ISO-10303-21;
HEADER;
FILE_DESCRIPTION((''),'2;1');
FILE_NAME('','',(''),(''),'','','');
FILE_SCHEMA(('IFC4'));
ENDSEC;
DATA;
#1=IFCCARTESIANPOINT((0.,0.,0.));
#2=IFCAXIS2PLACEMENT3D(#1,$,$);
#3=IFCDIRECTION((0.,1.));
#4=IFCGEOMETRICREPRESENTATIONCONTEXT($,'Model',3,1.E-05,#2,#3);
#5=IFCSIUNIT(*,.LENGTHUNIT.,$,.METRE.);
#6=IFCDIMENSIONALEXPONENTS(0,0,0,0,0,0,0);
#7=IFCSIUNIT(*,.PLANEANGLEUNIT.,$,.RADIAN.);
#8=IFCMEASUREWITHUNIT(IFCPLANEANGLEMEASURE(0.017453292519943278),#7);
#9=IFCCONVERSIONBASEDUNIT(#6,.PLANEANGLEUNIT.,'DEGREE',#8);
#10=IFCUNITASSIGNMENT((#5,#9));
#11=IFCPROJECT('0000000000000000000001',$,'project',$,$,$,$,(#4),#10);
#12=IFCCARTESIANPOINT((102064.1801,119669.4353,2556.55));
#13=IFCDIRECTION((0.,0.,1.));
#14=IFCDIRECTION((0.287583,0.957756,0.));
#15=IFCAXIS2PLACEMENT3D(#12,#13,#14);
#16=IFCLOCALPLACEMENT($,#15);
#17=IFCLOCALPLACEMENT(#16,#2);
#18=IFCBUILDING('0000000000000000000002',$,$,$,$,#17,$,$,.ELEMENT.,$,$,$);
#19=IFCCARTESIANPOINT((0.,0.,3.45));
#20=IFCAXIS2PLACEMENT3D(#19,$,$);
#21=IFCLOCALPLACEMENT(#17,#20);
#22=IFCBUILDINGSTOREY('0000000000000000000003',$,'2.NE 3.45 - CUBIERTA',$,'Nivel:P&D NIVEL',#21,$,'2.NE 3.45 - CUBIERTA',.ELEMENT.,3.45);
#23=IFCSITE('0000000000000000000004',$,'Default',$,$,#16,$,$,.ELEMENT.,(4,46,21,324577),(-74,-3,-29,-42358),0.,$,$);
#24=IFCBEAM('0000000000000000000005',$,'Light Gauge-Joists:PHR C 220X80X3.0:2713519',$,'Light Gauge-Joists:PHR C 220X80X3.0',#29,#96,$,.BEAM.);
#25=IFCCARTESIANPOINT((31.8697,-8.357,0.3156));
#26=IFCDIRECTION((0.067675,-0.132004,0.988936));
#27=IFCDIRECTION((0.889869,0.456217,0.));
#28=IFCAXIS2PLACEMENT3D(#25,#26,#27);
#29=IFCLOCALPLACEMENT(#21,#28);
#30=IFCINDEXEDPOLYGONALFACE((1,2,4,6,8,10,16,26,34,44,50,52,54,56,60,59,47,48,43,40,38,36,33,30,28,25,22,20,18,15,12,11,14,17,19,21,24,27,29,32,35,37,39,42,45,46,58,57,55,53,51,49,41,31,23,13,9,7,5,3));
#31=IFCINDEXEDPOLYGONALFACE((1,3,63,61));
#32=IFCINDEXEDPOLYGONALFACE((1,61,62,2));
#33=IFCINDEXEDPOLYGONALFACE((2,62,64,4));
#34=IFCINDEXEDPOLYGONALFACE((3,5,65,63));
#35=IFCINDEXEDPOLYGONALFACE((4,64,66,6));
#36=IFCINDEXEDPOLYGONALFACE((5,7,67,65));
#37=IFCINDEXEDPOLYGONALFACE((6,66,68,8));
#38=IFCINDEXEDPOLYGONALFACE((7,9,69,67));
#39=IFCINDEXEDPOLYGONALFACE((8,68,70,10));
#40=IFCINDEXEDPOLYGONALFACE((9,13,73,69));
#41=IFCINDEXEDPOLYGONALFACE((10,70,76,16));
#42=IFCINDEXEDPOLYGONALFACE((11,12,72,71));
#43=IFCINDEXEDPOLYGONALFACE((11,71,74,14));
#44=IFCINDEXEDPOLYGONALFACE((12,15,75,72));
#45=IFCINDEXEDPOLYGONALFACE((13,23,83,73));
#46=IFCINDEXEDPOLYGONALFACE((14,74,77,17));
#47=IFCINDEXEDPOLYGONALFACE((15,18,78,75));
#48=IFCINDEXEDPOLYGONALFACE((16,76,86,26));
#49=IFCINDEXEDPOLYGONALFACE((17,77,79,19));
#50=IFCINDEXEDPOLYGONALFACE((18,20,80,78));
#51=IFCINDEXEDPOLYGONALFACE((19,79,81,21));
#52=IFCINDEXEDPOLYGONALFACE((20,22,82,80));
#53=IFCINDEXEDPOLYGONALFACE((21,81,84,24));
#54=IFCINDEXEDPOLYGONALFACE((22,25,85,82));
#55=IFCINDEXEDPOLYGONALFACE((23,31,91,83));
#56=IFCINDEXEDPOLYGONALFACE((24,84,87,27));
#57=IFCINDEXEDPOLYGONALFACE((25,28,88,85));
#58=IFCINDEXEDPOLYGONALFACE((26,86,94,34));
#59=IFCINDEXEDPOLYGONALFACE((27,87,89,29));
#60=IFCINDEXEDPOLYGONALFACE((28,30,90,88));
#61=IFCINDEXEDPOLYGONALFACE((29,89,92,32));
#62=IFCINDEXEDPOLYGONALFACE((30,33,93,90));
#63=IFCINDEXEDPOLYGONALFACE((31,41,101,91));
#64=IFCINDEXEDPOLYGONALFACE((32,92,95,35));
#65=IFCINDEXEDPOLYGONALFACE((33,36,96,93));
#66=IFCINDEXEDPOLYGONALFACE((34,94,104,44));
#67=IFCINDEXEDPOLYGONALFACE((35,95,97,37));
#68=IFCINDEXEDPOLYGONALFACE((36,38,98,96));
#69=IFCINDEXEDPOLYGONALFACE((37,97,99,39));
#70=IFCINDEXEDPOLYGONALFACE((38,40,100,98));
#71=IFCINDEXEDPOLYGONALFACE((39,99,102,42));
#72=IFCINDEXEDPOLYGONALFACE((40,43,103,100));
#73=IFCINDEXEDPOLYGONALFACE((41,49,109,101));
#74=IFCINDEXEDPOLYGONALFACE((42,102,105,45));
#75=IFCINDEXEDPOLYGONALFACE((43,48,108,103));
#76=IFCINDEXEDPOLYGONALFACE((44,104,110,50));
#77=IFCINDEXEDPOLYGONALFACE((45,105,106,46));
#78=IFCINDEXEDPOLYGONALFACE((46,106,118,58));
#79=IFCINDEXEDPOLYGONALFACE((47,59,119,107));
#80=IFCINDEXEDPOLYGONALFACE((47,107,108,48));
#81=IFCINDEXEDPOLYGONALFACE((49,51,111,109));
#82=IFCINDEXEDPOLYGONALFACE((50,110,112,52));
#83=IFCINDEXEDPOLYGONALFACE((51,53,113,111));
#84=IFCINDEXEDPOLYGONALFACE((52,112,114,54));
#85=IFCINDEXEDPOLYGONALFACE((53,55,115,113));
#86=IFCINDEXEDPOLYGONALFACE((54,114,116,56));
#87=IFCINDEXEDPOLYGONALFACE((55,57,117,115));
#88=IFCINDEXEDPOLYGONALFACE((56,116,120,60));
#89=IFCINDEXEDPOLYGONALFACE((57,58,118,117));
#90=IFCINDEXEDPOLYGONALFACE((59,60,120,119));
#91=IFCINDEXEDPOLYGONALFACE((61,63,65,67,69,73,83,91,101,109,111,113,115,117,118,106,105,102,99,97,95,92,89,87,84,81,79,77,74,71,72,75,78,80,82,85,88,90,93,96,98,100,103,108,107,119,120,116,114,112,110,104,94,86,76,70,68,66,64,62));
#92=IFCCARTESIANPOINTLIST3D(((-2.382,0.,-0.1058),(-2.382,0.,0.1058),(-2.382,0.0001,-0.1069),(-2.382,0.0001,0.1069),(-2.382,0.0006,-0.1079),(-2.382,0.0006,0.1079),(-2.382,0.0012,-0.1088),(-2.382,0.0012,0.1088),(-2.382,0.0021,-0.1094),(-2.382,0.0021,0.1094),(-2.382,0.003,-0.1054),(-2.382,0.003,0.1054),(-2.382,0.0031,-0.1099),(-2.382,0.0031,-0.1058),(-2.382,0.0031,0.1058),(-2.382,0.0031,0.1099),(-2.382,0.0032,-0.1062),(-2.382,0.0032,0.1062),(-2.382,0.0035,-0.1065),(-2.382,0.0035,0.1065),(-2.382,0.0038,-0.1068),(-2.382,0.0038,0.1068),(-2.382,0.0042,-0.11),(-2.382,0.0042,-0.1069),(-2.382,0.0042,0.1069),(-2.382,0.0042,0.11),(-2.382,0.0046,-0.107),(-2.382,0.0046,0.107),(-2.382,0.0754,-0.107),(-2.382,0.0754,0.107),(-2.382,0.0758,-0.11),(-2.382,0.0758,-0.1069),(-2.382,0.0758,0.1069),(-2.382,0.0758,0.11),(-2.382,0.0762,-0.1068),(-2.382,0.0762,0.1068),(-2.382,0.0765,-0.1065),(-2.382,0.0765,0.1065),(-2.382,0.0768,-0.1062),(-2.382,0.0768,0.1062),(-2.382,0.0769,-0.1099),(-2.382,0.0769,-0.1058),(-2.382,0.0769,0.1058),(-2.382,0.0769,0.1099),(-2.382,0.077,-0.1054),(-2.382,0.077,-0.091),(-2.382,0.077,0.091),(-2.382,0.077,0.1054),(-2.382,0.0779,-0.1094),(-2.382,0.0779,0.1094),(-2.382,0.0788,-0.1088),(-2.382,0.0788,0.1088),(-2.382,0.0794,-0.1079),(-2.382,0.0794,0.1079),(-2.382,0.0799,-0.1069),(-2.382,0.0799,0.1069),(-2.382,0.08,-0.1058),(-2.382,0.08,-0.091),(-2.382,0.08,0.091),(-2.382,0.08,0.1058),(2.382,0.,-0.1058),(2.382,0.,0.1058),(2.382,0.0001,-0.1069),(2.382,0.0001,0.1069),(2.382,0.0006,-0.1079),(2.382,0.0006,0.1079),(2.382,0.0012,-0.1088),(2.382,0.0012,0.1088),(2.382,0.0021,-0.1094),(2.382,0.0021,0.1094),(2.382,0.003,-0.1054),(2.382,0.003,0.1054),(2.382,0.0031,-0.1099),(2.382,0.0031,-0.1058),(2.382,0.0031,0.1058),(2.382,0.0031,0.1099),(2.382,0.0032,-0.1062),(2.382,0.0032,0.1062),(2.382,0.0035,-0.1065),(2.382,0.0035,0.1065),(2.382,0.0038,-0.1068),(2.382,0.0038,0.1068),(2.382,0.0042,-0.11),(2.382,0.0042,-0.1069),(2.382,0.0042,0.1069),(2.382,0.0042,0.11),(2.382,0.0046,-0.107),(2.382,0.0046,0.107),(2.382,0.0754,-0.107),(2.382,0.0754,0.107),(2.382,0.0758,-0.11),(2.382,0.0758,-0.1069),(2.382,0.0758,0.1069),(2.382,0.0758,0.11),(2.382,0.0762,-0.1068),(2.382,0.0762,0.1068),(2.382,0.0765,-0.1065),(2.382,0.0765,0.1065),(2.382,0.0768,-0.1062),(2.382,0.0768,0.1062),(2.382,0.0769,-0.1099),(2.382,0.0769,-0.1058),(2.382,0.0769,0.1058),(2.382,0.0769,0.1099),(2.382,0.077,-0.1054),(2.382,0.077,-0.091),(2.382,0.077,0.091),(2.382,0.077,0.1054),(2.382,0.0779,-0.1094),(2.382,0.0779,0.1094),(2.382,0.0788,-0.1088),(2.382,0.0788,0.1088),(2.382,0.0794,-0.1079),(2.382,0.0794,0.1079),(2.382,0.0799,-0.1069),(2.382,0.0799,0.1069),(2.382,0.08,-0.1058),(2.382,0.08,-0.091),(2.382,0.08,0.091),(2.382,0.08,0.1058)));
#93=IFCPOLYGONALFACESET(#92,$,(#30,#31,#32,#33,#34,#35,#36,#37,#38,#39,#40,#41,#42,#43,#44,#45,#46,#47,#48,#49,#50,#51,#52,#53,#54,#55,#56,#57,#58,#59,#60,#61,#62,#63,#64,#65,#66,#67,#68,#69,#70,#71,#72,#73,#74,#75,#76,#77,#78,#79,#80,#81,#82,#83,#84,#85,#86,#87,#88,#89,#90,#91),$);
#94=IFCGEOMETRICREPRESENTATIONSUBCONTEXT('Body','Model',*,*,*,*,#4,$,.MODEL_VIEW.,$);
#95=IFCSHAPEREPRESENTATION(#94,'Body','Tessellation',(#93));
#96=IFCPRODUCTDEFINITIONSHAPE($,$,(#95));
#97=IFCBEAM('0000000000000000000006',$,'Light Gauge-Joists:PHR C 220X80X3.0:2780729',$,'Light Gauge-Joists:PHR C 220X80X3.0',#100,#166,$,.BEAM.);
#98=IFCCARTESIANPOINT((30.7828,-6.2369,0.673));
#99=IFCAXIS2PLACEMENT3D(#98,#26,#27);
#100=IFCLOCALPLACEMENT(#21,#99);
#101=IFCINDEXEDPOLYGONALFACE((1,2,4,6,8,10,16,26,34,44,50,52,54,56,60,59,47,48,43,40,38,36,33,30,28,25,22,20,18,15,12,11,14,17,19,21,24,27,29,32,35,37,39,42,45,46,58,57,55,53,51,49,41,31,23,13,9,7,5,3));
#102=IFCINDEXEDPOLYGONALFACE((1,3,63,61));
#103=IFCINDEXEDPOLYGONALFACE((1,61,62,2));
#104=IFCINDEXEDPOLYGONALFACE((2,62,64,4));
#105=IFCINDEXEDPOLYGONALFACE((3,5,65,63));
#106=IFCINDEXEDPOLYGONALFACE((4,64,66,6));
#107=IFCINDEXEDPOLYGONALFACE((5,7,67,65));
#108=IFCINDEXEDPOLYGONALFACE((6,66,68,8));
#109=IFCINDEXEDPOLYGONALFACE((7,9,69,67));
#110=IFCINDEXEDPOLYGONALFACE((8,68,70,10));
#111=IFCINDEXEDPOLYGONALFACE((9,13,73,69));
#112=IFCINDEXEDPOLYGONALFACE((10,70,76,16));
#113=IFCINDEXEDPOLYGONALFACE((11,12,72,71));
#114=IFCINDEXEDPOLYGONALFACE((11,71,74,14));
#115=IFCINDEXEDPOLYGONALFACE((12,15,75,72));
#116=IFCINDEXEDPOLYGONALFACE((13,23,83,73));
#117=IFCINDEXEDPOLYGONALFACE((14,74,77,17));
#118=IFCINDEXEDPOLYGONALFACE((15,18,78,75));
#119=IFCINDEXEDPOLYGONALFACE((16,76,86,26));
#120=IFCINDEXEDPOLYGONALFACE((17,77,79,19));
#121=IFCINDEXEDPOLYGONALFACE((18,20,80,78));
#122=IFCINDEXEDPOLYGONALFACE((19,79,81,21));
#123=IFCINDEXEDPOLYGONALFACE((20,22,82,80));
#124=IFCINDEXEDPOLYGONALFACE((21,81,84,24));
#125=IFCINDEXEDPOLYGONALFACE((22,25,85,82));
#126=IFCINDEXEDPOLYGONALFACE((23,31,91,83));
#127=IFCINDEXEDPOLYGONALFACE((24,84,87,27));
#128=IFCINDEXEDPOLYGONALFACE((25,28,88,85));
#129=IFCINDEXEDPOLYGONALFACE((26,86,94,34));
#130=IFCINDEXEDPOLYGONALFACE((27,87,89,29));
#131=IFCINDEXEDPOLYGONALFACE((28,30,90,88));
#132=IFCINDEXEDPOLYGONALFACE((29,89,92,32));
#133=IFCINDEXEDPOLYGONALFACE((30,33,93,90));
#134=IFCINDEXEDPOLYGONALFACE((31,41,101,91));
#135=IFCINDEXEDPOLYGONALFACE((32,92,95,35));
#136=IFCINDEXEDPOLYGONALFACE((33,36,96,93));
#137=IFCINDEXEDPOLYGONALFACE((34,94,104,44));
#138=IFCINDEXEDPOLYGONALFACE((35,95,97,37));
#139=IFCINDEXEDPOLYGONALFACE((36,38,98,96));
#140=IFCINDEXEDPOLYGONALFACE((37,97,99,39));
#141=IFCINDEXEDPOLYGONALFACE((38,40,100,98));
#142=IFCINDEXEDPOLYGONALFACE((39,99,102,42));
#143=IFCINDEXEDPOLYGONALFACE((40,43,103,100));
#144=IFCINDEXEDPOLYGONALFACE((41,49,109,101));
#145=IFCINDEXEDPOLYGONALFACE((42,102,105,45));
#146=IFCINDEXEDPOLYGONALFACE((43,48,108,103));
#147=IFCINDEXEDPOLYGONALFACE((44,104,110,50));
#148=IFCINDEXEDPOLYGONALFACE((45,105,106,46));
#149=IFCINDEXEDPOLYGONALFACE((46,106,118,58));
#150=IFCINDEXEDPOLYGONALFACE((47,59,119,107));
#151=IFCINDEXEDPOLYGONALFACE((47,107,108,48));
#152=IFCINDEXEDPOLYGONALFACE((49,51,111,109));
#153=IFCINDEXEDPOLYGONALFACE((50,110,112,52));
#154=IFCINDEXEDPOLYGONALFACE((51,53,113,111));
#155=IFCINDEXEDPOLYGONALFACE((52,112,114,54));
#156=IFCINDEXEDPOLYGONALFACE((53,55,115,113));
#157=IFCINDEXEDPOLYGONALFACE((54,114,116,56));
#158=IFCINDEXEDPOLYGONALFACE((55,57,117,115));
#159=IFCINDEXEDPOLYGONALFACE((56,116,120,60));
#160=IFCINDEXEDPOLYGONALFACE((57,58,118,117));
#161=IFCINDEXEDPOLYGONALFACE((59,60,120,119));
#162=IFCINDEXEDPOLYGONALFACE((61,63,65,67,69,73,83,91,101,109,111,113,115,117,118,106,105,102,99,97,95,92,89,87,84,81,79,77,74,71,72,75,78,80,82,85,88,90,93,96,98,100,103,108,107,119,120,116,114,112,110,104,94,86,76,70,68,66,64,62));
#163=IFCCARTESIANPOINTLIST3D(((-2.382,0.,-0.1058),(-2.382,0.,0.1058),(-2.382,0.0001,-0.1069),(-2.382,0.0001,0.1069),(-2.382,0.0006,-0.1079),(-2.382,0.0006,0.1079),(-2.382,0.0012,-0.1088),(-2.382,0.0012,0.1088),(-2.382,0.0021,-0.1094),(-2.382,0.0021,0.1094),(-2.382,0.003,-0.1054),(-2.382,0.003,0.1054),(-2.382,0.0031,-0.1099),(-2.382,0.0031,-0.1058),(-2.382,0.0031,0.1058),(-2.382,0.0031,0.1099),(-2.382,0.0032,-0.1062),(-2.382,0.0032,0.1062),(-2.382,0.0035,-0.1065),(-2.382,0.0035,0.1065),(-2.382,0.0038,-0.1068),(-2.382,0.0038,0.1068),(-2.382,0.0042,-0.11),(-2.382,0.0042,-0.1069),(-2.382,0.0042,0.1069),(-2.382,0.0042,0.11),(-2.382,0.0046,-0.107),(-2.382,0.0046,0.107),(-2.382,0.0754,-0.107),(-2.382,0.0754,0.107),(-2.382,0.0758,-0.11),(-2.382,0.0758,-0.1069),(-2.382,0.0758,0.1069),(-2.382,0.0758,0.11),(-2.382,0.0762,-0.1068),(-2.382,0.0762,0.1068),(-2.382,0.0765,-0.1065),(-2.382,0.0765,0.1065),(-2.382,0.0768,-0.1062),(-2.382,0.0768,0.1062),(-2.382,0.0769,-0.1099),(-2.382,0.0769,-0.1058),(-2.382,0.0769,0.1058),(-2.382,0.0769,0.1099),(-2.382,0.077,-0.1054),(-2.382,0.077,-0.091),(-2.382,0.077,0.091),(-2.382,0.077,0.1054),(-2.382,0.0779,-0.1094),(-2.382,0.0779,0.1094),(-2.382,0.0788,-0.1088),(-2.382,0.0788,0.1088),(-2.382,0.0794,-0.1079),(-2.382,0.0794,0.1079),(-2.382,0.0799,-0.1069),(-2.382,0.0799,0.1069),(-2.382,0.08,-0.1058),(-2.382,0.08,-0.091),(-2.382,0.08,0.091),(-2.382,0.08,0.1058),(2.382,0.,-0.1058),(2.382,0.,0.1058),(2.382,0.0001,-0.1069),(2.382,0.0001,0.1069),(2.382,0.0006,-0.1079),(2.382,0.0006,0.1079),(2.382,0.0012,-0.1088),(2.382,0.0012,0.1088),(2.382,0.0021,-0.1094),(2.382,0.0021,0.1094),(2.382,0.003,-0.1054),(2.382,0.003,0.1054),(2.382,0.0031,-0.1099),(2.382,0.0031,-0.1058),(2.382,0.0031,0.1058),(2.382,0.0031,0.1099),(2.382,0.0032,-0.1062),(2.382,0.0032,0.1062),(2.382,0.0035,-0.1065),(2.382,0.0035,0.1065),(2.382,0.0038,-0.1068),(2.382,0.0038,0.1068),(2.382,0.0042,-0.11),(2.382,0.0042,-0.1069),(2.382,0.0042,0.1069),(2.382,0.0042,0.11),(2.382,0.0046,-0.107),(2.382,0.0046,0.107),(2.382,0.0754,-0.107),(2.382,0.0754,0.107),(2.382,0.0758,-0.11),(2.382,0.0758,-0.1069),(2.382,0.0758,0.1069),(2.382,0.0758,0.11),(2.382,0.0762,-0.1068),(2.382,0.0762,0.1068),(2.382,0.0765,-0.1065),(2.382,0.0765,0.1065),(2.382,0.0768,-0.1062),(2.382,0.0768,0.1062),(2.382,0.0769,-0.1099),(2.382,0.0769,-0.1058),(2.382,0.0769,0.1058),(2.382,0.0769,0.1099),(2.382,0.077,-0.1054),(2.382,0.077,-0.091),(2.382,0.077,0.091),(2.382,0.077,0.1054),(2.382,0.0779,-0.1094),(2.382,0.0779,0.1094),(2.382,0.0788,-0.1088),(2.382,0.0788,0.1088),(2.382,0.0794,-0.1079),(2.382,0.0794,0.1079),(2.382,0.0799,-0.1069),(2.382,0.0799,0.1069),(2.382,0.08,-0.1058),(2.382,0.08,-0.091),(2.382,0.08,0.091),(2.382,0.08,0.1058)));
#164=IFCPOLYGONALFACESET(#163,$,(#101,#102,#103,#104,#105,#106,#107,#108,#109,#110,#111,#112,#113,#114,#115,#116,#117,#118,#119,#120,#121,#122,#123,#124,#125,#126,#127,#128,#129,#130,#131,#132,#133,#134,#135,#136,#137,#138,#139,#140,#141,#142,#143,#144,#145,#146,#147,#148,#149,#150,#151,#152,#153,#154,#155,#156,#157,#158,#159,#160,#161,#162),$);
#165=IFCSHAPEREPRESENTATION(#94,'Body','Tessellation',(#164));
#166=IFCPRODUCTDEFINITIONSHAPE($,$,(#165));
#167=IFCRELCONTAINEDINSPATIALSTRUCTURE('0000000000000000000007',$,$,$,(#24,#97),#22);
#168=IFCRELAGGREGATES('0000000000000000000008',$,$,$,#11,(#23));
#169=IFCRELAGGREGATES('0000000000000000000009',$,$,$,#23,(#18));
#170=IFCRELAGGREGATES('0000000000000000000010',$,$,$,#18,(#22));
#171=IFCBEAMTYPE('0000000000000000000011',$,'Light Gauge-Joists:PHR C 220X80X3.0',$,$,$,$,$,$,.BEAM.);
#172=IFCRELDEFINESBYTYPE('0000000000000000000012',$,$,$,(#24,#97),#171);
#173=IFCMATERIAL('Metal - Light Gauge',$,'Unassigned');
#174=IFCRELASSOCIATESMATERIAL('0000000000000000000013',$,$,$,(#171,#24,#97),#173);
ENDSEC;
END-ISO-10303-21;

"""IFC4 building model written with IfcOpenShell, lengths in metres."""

from ifc_helpers import new_model, entity, si_unit, converted_unit, direction, frame, origin, place, context, subcontext, project, spatial, line, arc, indexed_curve, outline, extrude, source, transform, mapped, material, type_object, type_shapes, element, save


model = new_model("IFC4")

# Units and contexts
model_context = context("Model", 3, precision=1e-05, world=origin(), true_north=direction((0.0, 1.0)))
body_context = subcontext(model_context, "Body", "Model", "MODEL_VIEW")
ifc_project = project(units=[si_unit("LENGTHUNIT", "METRE"), converted_unit("PLANEANGLEUNIT", "DEGREE", entity("IfcPlaneAngleMeasure", 0.017453292519943278), si_unit("PLANEANGLEUNIT", "RADIAN"), dimensions=[0, 0, 0, 0, 0, 0, 0])], contexts=[model_context])

# Site, building, storey
site_placement = place(None, frame((102064.1801, 119669.4353, 2556.55), z_axis=(0.0, 0.0, 1.0), x_axis=(0.287583, 0.957756, 0.0)))
site = spatial("IfcSite", under=ifc_project, at=site_placement, Name="Default", CompositionType="ELEMENT", RefLatitude=(4, 46, 21, 324577), RefLongitude=(-74, -3, -29, -42358), RefElevation=0.0)
building_placement = place(site_placement, origin())
building = spatial("IfcBuilding", under=site, at=building_placement, CompositionType="ELEMENT")
storey_placement = place(building_placement, frame((0.0, 0.0, 3.45)))
storey = spatial("IfcBuildingStorey", under=building, at=storey_placement, Name="2.NE 3.45 - CUBIERTA", ObjectType="Nivel:P&D NIVEL", LongName="2.NE 3.45 - CUBIERTA", CompositionType="ELEMENT", Elevation=3.45)

# Beams
ifc_material_1 = material(Name="Metal - Light Gauge", Category="Unassigned")
beam_type_1 = type_object("IfcBeamType", Name="Light Gauge-Joists:PHR C 220X80X3.0", PredefinedType="BEAM", material=ifc_material_1)
shared_shape_1 = source(origin(), body_context, "Body", "SweptSolid", [
    extrude(outline(indexed_curve([(-0.0477, -0.1058), (-0.0465, -0.1088), (-0.0435, -0.11), (0.0281, -0.11), (0.0311, -0.1088), (0.0323, -0.1058), (0.0323, -0.091), (0.0293, -0.091), (0.0293, -0.1054), (0.0288, -0.1065), (0.0277, -0.107), (-0.0431, -0.107), (-0.0442, -0.1065), (-0.0447, -0.1054), (-0.0447, 0.1054), (-0.0442, 0.1065), (-0.0431, 0.107), (0.0277, 0.107), (0.0288, 0.1065), (0.0293, 0.1054), (0.0293, 0.091), (0.0323, 0.091), (0.0323, 0.1058), (0.0311, 0.1088), (0.0281, 0.11), (-0.0435, 0.11), (-0.0465, 0.1088), (-0.0477, 0.1058)], segments=[arc(1, 2, 3), line(3, 4), arc(4, 5, 6), line(6, 7, 8, 9), arc(9, 10, 11), line(11, 12), arc(12, 13, 14), line(14, 15), arc(15, 16, 17), line(17, 18), arc(18, 19, 20), line(20, 21, 22, 23), arc(23, 24, 25), line(25, 26), arc(26, 27, 28), line(28, 1)], self_intersect=False)), frame((-2.382, 0.0477, 0.0), z_axis=(1.0, 0.0, 0.0), x_axis=(0.0, 1.0, 0.0)), (0.0, 0.0, 1.0), 4.764),
])
type_shapes(beam_type_1, [shared_shape_1])
for number, where, z_axis, x_axis, name in (
    (1, (31.8697, -8.357, 0.3156), (0.067675, -0.132004, 0.988936), (0.889869, 0.456217, 0.0), "Light Gauge-Joists:PHR C 220X80X3.0:2713519"),
    (2, (30.7828, -6.2369, 0.673), (0.067675, -0.132004, 0.988936), (0.889869, 0.456217, 0.0), "Light Gauge-Joists:PHR C 220X80X3.0:2780729"),
):
    element("IfcBeam", number, at=place(storey_placement, frame(where, z_axis=z_axis, x_axis=x_axis)), inside=storey, type_object=beam_type_1, material=ifc_material_1, Name=name, ObjectType="Light Gauge-Joists:PHR C 220X80X3.0", PredefinedType="BEAM", context=body_context, shape_type="MappedRepresentation", body=[
        mapped(shared_shape_1, transform((0.0, 0.0, 0.0), scale=1.0)),
    ])

save(model, "model.ifc")
